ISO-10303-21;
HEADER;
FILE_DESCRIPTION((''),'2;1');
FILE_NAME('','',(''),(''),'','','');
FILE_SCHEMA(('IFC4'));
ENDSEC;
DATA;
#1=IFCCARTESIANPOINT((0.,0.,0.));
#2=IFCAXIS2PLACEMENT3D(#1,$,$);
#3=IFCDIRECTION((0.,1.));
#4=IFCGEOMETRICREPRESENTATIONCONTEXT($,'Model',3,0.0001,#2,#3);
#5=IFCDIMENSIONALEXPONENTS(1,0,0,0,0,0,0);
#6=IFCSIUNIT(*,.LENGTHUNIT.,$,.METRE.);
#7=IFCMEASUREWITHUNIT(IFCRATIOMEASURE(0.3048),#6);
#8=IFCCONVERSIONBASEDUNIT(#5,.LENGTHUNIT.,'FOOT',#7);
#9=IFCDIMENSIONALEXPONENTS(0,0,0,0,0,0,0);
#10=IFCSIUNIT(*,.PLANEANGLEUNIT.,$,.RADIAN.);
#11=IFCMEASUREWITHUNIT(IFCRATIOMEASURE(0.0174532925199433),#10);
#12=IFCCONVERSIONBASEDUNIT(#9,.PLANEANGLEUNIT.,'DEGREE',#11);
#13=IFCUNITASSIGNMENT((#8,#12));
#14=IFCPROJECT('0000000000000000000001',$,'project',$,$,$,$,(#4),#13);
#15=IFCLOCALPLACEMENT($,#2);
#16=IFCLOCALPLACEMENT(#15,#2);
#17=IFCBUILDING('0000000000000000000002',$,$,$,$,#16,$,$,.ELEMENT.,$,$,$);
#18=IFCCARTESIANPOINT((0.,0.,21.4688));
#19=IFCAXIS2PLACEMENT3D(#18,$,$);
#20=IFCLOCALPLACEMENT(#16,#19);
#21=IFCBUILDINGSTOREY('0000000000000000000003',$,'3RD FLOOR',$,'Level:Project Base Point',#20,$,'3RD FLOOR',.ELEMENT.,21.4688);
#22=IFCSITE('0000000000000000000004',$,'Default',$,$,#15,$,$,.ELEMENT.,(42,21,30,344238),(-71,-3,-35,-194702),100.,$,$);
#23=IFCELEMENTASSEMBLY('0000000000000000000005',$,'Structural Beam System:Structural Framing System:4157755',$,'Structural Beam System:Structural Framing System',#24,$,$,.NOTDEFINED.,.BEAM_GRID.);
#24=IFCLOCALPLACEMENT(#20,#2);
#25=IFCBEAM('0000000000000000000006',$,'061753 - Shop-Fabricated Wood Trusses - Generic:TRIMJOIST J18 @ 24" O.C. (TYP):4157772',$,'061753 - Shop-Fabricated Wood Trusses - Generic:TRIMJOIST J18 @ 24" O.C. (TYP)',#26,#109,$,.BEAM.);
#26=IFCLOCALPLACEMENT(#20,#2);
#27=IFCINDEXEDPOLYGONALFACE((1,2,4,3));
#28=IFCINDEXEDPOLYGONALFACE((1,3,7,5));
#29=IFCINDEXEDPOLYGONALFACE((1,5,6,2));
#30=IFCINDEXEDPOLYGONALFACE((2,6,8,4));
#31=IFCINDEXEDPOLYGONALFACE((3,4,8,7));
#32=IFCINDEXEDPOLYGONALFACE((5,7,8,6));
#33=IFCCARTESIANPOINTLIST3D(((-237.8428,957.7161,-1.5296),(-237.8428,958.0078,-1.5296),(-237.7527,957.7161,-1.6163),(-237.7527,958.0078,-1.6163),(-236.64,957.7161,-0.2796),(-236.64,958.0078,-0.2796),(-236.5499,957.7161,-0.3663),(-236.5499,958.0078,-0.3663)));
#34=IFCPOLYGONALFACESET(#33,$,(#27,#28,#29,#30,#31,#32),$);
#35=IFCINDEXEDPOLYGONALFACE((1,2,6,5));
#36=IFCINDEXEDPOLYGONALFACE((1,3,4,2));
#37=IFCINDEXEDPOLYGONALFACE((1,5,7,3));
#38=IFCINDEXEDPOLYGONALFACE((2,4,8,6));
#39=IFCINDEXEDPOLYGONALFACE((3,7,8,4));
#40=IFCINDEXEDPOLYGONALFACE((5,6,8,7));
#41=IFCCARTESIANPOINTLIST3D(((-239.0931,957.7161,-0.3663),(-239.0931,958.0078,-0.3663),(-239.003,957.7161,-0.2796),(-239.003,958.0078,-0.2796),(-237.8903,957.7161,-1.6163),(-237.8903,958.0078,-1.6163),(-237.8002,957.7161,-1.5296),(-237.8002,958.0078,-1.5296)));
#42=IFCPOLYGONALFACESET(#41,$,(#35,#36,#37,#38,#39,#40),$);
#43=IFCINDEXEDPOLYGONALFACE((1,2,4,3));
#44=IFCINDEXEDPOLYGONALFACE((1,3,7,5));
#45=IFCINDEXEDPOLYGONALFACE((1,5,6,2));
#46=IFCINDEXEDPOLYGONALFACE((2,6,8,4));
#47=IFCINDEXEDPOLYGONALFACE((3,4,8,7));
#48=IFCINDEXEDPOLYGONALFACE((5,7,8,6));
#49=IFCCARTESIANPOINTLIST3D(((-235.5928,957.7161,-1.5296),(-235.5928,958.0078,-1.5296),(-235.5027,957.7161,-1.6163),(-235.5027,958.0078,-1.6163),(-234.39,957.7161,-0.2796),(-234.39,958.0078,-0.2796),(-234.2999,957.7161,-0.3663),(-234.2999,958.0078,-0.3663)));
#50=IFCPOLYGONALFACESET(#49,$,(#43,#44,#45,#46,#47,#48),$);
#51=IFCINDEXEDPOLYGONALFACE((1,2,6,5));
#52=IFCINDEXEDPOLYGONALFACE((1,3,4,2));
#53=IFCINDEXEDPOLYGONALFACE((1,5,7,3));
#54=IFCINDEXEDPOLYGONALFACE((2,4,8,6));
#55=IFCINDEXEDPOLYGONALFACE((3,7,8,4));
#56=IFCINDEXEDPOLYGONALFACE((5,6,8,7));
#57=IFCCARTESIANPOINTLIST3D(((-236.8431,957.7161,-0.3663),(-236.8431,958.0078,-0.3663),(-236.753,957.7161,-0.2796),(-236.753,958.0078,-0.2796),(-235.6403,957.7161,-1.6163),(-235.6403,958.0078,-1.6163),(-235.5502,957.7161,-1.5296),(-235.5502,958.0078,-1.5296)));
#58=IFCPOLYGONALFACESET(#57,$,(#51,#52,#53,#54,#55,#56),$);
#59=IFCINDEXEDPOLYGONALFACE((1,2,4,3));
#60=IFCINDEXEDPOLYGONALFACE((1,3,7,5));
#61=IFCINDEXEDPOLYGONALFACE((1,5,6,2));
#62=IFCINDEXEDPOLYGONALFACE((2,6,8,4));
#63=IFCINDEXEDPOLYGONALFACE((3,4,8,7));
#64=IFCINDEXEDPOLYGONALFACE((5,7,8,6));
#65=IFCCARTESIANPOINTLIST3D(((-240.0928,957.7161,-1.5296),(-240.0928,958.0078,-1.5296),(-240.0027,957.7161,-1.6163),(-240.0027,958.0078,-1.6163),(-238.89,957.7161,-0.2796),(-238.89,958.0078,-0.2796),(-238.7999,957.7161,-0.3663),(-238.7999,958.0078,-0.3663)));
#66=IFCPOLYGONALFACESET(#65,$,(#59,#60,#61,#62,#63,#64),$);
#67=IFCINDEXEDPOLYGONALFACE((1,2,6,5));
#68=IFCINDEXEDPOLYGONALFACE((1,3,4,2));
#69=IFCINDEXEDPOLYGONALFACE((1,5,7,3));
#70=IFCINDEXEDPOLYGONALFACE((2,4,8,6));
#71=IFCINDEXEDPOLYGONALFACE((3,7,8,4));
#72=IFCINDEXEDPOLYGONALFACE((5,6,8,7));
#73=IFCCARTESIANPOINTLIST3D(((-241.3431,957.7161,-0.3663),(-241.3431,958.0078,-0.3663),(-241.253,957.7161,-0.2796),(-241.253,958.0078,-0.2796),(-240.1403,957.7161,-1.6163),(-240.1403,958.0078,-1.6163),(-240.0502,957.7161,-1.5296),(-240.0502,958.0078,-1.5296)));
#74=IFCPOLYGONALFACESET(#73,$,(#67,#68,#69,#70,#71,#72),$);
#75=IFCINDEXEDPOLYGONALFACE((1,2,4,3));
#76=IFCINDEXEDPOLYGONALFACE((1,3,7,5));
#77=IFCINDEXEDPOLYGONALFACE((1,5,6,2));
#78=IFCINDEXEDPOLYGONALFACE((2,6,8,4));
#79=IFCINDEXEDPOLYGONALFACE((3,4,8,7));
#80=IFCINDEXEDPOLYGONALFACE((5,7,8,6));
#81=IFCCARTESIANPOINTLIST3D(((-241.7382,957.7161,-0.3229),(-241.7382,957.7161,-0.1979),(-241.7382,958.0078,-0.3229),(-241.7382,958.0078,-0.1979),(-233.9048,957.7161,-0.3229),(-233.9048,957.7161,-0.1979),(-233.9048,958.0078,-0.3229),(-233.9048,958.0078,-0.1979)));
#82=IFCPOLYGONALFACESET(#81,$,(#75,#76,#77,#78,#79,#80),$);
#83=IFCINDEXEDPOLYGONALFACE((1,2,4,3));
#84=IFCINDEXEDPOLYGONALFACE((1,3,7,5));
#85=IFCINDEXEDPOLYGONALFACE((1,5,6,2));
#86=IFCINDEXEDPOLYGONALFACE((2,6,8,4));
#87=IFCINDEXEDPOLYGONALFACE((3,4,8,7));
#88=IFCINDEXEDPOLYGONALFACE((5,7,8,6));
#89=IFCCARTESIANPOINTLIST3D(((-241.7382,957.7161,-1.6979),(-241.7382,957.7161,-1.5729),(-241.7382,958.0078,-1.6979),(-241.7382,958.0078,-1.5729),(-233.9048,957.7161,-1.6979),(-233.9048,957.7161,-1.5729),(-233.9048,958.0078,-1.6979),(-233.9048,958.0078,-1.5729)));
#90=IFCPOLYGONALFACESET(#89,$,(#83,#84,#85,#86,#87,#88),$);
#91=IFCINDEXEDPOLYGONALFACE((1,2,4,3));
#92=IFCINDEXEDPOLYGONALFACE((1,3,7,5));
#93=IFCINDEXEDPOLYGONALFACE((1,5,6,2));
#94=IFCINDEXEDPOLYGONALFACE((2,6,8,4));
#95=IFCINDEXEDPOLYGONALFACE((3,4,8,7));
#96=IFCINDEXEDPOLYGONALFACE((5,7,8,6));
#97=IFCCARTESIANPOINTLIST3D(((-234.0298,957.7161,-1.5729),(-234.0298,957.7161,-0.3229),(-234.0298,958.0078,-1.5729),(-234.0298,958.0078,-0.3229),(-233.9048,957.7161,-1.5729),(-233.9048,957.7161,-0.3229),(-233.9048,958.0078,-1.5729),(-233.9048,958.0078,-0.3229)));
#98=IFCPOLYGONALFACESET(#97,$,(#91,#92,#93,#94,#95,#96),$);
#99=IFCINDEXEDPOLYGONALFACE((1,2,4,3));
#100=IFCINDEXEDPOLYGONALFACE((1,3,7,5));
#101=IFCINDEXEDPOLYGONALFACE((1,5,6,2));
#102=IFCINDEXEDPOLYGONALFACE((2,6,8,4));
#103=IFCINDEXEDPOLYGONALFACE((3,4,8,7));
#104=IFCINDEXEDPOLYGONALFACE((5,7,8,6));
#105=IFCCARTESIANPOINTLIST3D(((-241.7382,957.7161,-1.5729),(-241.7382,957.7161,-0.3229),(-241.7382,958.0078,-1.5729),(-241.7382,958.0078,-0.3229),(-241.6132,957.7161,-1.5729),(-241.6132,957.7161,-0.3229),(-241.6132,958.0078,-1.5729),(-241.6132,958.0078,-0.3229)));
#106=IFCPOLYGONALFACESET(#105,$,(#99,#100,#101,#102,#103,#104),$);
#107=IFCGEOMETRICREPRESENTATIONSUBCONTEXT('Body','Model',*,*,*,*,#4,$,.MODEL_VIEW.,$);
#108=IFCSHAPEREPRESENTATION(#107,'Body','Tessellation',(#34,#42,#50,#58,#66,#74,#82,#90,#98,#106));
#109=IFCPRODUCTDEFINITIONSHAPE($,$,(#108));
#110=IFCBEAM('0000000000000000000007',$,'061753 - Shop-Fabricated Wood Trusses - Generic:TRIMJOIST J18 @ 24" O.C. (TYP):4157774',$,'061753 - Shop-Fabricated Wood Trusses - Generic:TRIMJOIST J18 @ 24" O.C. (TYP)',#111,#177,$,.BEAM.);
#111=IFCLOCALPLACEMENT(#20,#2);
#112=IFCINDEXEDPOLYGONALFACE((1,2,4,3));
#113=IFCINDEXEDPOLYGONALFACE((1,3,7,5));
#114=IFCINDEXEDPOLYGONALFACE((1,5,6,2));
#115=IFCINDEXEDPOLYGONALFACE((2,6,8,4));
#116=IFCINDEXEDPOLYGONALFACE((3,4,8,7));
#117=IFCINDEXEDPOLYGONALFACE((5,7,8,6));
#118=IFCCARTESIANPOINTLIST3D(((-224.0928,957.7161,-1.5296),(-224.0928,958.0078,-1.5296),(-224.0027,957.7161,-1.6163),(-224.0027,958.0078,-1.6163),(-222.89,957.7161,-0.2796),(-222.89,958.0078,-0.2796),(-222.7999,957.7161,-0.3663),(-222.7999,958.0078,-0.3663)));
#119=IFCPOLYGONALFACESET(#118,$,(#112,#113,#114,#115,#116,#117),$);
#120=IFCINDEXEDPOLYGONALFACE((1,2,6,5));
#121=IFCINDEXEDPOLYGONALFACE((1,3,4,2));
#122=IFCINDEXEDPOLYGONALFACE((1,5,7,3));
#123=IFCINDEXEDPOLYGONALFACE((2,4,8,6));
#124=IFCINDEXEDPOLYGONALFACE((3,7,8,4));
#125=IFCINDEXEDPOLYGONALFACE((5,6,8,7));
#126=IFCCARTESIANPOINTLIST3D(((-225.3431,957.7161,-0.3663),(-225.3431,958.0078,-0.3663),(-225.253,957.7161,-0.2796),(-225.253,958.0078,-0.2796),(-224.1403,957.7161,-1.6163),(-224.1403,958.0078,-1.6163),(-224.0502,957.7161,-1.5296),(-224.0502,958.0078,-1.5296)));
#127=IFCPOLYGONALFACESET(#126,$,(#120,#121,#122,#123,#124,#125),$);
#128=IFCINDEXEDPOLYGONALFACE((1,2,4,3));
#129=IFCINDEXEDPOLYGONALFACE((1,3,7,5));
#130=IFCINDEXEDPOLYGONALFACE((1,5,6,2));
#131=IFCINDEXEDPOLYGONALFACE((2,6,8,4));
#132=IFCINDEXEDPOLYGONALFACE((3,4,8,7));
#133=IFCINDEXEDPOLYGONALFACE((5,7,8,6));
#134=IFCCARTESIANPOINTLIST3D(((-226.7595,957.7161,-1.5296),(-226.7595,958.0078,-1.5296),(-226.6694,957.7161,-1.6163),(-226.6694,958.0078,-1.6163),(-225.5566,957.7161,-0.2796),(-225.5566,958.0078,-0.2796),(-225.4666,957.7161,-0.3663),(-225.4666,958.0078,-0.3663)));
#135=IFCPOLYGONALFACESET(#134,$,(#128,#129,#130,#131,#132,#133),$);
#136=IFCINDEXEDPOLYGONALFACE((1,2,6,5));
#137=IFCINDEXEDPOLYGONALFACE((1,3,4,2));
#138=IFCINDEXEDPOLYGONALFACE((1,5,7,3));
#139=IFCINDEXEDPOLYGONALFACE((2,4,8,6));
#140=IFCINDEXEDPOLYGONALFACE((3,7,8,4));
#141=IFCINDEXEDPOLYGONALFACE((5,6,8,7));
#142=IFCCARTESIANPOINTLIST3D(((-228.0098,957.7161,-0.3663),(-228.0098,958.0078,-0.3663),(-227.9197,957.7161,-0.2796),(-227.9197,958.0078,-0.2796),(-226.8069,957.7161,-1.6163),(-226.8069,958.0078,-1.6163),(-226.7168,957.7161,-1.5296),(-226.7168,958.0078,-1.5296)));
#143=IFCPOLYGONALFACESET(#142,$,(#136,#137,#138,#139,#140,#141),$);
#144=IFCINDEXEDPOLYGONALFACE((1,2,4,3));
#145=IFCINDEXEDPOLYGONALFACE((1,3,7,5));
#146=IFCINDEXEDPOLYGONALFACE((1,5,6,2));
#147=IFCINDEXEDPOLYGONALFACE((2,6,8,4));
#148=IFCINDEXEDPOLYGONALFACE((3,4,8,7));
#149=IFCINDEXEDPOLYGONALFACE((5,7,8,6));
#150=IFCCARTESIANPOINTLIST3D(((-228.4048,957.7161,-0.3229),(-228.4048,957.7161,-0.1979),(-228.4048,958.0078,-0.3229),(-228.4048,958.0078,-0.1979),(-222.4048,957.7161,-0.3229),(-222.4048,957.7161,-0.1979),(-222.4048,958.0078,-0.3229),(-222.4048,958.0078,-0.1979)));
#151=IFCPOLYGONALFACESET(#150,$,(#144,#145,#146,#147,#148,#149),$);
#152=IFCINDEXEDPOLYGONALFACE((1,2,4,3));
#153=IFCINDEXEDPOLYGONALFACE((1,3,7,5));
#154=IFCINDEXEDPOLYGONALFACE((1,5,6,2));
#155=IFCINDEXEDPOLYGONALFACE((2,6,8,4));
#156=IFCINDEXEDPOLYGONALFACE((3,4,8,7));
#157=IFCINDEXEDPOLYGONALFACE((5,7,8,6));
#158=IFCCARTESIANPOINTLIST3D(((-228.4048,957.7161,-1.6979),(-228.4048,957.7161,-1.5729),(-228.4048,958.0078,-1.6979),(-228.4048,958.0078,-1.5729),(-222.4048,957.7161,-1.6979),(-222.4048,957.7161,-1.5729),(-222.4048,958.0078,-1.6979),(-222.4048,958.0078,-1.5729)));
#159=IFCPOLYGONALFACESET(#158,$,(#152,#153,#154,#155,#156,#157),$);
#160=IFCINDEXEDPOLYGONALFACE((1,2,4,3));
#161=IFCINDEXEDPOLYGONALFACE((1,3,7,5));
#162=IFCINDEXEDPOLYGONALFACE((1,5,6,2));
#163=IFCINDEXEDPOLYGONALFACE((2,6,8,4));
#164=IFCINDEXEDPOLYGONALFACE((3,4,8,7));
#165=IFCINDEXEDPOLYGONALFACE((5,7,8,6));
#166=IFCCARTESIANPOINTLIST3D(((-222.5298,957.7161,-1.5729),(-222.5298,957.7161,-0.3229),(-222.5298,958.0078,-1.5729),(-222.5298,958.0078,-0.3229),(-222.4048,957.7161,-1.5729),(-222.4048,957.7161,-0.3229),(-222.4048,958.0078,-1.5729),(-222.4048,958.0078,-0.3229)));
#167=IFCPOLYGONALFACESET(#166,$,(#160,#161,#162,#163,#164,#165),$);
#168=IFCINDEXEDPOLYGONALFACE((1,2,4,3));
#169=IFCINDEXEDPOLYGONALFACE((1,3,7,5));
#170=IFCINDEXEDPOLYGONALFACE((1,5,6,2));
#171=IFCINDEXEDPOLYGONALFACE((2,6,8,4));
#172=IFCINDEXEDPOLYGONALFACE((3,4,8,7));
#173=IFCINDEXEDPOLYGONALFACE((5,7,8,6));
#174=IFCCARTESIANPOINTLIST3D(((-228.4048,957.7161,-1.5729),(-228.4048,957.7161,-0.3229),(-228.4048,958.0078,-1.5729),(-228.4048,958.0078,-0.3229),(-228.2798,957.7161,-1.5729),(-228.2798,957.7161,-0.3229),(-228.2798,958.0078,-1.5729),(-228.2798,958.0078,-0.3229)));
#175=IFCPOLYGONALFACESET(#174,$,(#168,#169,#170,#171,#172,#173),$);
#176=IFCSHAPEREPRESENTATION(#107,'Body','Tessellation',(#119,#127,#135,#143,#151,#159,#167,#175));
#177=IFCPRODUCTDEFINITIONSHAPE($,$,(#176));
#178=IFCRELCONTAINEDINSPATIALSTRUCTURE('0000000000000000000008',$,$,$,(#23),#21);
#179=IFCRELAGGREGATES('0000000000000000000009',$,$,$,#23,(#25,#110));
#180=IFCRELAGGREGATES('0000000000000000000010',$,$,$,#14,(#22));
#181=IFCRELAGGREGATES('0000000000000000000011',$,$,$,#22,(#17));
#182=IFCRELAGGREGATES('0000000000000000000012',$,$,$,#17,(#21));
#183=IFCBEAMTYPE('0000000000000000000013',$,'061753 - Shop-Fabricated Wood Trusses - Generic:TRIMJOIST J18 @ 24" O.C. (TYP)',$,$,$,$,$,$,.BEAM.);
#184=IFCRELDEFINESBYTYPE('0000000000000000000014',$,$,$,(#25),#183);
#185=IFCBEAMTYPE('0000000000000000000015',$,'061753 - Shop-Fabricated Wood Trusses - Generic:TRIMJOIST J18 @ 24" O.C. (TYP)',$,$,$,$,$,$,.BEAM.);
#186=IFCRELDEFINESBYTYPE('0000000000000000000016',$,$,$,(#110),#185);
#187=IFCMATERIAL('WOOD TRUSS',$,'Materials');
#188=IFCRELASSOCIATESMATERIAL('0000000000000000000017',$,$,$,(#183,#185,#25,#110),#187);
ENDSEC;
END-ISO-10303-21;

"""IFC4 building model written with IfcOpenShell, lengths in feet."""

from ifc_helpers import new_model, entity, si_unit, converted_unit, direction, frame, frame_2d, origin, origin_2d_with_axis, place, context, subcontext, project, spatial, rectangle, extrude, source, transform, mapped, material, material_profile, profile_set, profile_usage, type_object, type_shapes, element, aggregate, save


model = new_model("IFC4")

# Units and contexts
model_context = context("Model", 3, precision=0.0001, world=origin(), true_north=direction((0.0, 1.0)))
body_context = subcontext(model_context, "Body", "Model", "MODEL_VIEW")
ifc_project = project(units=[converted_unit("LENGTHUNIT", "FOOT", entity("IfcRatioMeasure", 0.3048), si_unit("LENGTHUNIT", "METRE"), dimensions=[1, 0, 0, 0, 0, 0, 0]), converted_unit("PLANEANGLEUNIT", "DEGREE", entity("IfcRatioMeasure", 0.0174532925199433), si_unit("PLANEANGLEUNIT", "RADIAN"), dimensions=[0, 0, 0, 0, 0, 0, 0])], contexts=[model_context])

# Site, building, storey
site_placement = place(None, origin())
site = spatial("IfcSite", under=ifc_project, at=site_placement, Name="Default", CompositionType="ELEMENT", RefLatitude=(42, 21, 30, 344238), RefLongitude=(-71, -3, -35, -194702), RefElevation=100.0)
building_placement = place(site_placement, origin())
building = spatial("IfcBuilding", under=site, at=building_placement, CompositionType="ELEMENT")
storey_placement = place(building_placement, frame((0.0, 0.0, 21.4688)))
storey = spatial("IfcBuildingStorey", under=building, at=storey_placement, Name="3RD FLOOR", ObjectType="Level:Project Base Point", LongName="3RD FLOOR", CompositionType="ELEMENT", Elevation=21.4688)

# Element assembly, beams
assembly_1_placement = place(storey_placement, origin())
assembly_1 = element("IfcElementAssembly", 1, at=assembly_1_placement, inside=storey, Name="Structural Beam System:Structural Framing System:4157755", ObjectType="Structural Beam System:Structural Framing System", AssemblyPlace="NOTDEFINED", PredefinedType="BEAM_GRID")
ifc_material_1 = material(Name="WOOD TRUSS", Category="Materials")
ifc_material_profile_1 = material_profile(ifc_material_1, rectangle(XDim=1.7347, YDim=0.125, at=frame_2d((0.0, 0.0), x_axis=(1.0, 0.0))), Name="TRIMJOIST J18 @ 24\" O.C. (TYP)")
ifc_material_profile_2 = material_profile(ifc_material_1, rectangle(XDim=1.7347, YDim=0.125, at=frame_2d((0.0, 0.0), x_axis=(1.0, 0.0))), Name="TRIMJOIST J18 @ 24\" O.C. (TYP)")
ifc_material_profile_3 = material_profile(ifc_material_1, rectangle(XDim=1.7347, YDim=0.125, at=frame_2d((0.0, 0.0), x_axis=(1.0, 0.0))), Name="TRIMJOIST J18 @ 24\" O.C. (TYP)")
ifc_material_profile_4 = material_profile(ifc_material_1, rectangle(XDim=1.7347, YDim=0.125, at=frame_2d((0.0, 0.0), x_axis=(1.0, 0.0))), Name="TRIMJOIST J18 @ 24\" O.C. (TYP)")
ifc_material_profile_5 = material_profile(ifc_material_1, rectangle(XDim=1.7347, YDim=0.125, at=frame_2d((0.0, 0.0), x_axis=(1.0, 0.0))), Name="TRIMJOIST J18 @ 24\" O.C. (TYP)")
ifc_material_profile_6 = material_profile(ifc_material_1, rectangle(XDim=1.7347, YDim=0.125, at=frame_2d((0.0, 0.0), x_axis=(1.0, 0.0))), Name="TRIMJOIST J18 @ 24\" O.C. (TYP)")
ifc_material_profile_7 = material_profile(ifc_material_1, rectangle(XDim=1.7347, YDim=0.125, at=frame_2d((0.0, 0.0), x_axis=(1.0, 0.0))), Name="TRIMJOIST J18 @ 24\" O.C. (TYP)")
ifc_material_profile_8 = material_profile(ifc_material_1, rectangle(XDim=1.7347, YDim=0.125, at=frame_2d((0.0, 0.0), x_axis=(1.0, 0.0))), Name="TRIMJOIST J18 @ 24\" O.C. (TYP)")
ifc_material_profile_9 = material_profile(ifc_material_1, rectangle(XDim=1.7347, YDim=0.125, at=frame_2d((0.0, 0.0), x_axis=(1.0, 0.0))), Name="TRIMJOIST J18 @ 24\" O.C. (TYP)")
ifc_material_profile_10 = material_profile(ifc_material_1, rectangle(XDim=1.7347, YDim=0.125, at=origin_2d_with_axis()), Name="TRIMJOIST J18 @ 24\" O.C. (TYP)")
ifc_material_profile_11 = material_profile(ifc_material_1, rectangle(XDim=0.125, YDim=0.2917, at=origin_2d_with_axis()), Name="TRIMJOIST J18 @ 24\" O.C. (TYP)")
ifc_material_profile_12 = material_profile(ifc_material_1, rectangle(XDim=0.125, YDim=0.2917, at=origin_2d_with_axis()), Name="TRIMJOIST J18 @ 24\" O.C. (TYP)")
ifc_material_profile_13 = material_profile(ifc_material_1, rectangle(XDim=1.25, YDim=0.2917, at=origin_2d_with_axis()), Name="TRIMJOIST J18 @ 24\" O.C. (TYP)")
ifc_material_profile_14 = material_profile(ifc_material_1, rectangle(XDim=1.25, YDim=0.2917, at=origin_2d_with_axis()), Name="TRIMJOIST J18 @ 24\" O.C. (TYP)")
ifc_profile_set_1 = profile_set([ifc_material_profile_1, ifc_material_profile_2, ifc_material_profile_3, ifc_material_profile_4, ifc_material_profile_5, ifc_material_profile_6, ifc_material_profile_7, ifc_material_profile_8, ifc_material_profile_9, ifc_material_profile_10, ifc_material_profile_11, ifc_material_profile_12, ifc_material_profile_13, ifc_material_profile_14], Name="TRIMJOIST J18 @ 24\" O.C. (TYP)")
ifc_profile_usage_1 = profile_usage(ifc_profile_set_1, cardinal=8)
beam_type_1 = type_object("IfcBeamType", Name="061753 - Shop-Fabricated Wood Trusses - Generic:TRIMJOIST J18 @ 24\" O.C. (TYP)", PredefinedType="BEAM", material=ifc_profile_set_1)
shared_shape_1 = source(origin(), body_context, "Body", "SweptSolid", [
    extrude(rectangle(XDim=1.7347, YDim=0.125, at=frame_2d((0.0, 0.0), x_axis=(1.0, 0.0))), frame((0.6251, -0.1458, 0.0), z_axis=(0.0, 1.0, 0.0), x_axis=(0.693383, 0.0, 0.720569)), (0.0, 0.0, 1.0), 0.2917),
    extrude(rectangle(XDim=1.7347, YDim=0.125, at=frame_2d((0.0, 0.0), x_axis=(1.0, 0.0))), frame((-0.6251, -0.1458, 0.0), z_axis=(0.0, 1.0, 0.0), x_axis=(0.693383, 0.0, -0.720569)), (0.0, 0.0, 1.0), 0.2917),
    extrude(rectangle(XDim=1.7347, YDim=0.125, at=frame_2d((0.0, 0.0), x_axis=(1.0, 0.0))), frame((2.8751, -0.1458, 0.0), z_axis=(0.0, 1.0, 0.0), x_axis=(0.693383, 0.0, 0.720569)), (0.0, 0.0, 1.0), 0.2917),
    extrude(rectangle(XDim=1.7347, YDim=0.125, at=frame_2d((0.0, 0.0), x_axis=(1.0, 0.0))), frame((1.6249, -0.1458, 0.0), z_axis=(0.0, 1.0, 0.0), x_axis=(0.693383, 0.0, -0.720569)), (0.0, 0.0, 1.0), 0.2917),
    extrude(rectangle(XDim=1.7347, YDim=0.125, at=frame_2d((0.0, 0.0), x_axis=(1.0, 0.0))), frame((-1.6249, -0.1458, 0.0), z_axis=(0.0, 1.0, 0.0), x_axis=(0.693383, 0.0, 0.720569)), (0.0, 0.0, 1.0), 0.2917),
    extrude(rectangle(XDim=1.7347, YDim=0.125, at=origin_2d_with_axis()), frame((-2.8751, -0.1458, 0.0), z_axis=(0.0, 1.0, 0.0), x_axis=(0.693383, 0.0, -0.720569)), (0.0, 0.0, 1.0), 0.2917),
    extrude(rectangle(XDim=0.125, YDim=0.2917, at=origin_2d_with_axis()), frame((-3.9167, 0.0, 0.6875), z_axis=(1.0, 0.0, 0.0), x_axis=(0.0, 0.0, -1.0)), (0.0, 0.0, 1.0), 7.8333),
    extrude(rectangle(XDim=0.125, YDim=0.2917, at=origin_2d_with_axis()), frame((-3.9167, 0.0, -0.6875), z_axis=(1.0, 0.0, 0.0), x_axis=(0.0, 0.0, -1.0)), (0.0, 0.0, 1.0), 7.8333),
    extrude(rectangle(XDim=1.25, YDim=0.2917, at=origin_2d_with_axis()), frame((3.7917, 0.0, 0.0), z_axis=(1.0, 0.0, 0.0), x_axis=(0.0, 0.0, -1.0)), (0.0, 0.0, 1.0), 0.125),
    extrude(rectangle(XDim=1.25, YDim=0.2917, at=origin_2d_with_axis()), frame((-3.9167, 0.0, 0.0), z_axis=(1.0, 0.0, 0.0), x_axis=(0.0, 0.0, -1.0)), (0.0, 0.0, 1.0), 0.125),
])
type_shapes(beam_type_1, [shared_shape_1])
beam_1_placement = place(assembly_1_placement, frame((-237.8215, 957.8619, -0.9479)))
beam_1 = element("IfcBeam", 2, at=beam_1_placement, type_object=beam_type_1, material=ifc_profile_usage_1, Name="061753 - Shop-Fabricated Wood Trusses - Generic:TRIMJOIST J18 @ 24\" O.C. (TYP):4157772", ObjectType="061753 - Shop-Fabricated Wood Trusses - Generic:TRIMJOIST J18 @ 24\" O.C. (TYP)", PredefinedType="BEAM", context=body_context, shape_type="MappedRepresentation", body=[
    mapped(shared_shape_1, transform((0.0, 0.0, 0.0), scale=1.0)),
])
ifc_profile_usage_2 = profile_usage(ifc_profile_set_1, cardinal=8)
beam_type_2 = type_object("IfcBeamType", Name="061753 - Shop-Fabricated Wood Trusses - Generic:TRIMJOIST J18 @ 24\" O.C. (TYP)", PredefinedType="BEAM", material=ifc_profile_set_1)
shared_shape_2 = source(origin(), body_context, "Body", "SweptSolid", [
    extrude(rectangle(XDim=1.7347, YDim=0.125, at=frame_2d((0.0, 0.0), x_axis=(1.0, 0.0))), frame((1.9585, -0.1458, 0.0), z_axis=(0.0, 1.0, 0.0), x_axis=(0.693383, 0.0, 0.720569)), (0.0, 0.0, 1.0), 0.2917),
    extrude(rectangle(XDim=1.7347, YDim=0.125, at=frame_2d((0.0, 0.0), x_axis=(1.0, 0.0))), frame((0.7082, -0.1458, 0.0), z_axis=(0.0, 1.0, 0.0), x_axis=(0.693383, 0.0, -0.720569)), (0.0, 0.0, 1.0), 0.2917),
    extrude(rectangle(XDim=1.7347, YDim=0.125, at=frame_2d((0.0, 0.0), x_axis=(1.0, 0.0))), frame((-0.7082, -0.1458, 0.0), z_axis=(0.0, 1.0, 0.0), x_axis=(0.693383, 0.0, 0.720569)), (0.0, 0.0, 1.0), 0.2917),
    extrude(rectangle(XDim=1.7347, YDim=0.125, at=frame_2d((0.0, 0.0), x_axis=(1.0, 0.0))), frame((-1.9585, -0.1458, 0.0), z_axis=(0.0, 1.0, 0.0), x_axis=(0.693383, 0.0, -0.720569)), (0.0, 0.0, 1.0), 0.2917),
    extrude(rectangle(XDim=0.125, YDim=0.2917, at=origin_2d_with_axis()), frame((-3.0, 0.0, 0.6875), z_axis=(1.0, 0.0, 0.0), x_axis=(0.0, 0.0, -1.0)), (0.0, 0.0, 1.0), 6.0),
    extrude(rectangle(XDim=0.125, YDim=0.2917, at=origin_2d_with_axis()), frame((-3.0, 0.0, -0.6875), z_axis=(1.0, 0.0, 0.0), x_axis=(0.0, 0.0, -1.0)), (0.0, 0.0, 1.0), 6.0),
    extrude(rectangle(XDim=1.25, YDim=0.2917, at=origin_2d_with_axis()), frame((2.875, 0.0, 0.0), z_axis=(1.0, 0.0, 0.0), x_axis=(0.0, 0.0, -1.0)), (0.0, 0.0, 1.0), 0.125),
    extrude(rectangle(XDim=1.25, YDim=0.2917, at=origin_2d_with_axis()), frame((-3.0, 0.0, 0.0), z_axis=(1.0, 0.0, 0.0), x_axis=(0.0, 0.0, -1.0)), (0.0, 0.0, 1.0), 0.125),
])
type_shapes(beam_type_2, [shared_shape_2])
beam_2_placement = place(assembly_1_placement, frame((-225.4048, 957.8619, -0.9479)))
beam_2 = element("IfcBeam", 3, at=beam_2_placement, type_object=beam_type_2, material=ifc_profile_usage_2, Name="061753 - Shop-Fabricated Wood Trusses - Generic:TRIMJOIST J18 @ 24\" O.C. (TYP):4157774", ObjectType="061753 - Shop-Fabricated Wood Trusses - Generic:TRIMJOIST J18 @ 24\" O.C. (TYP)", PredefinedType="BEAM", context=body_context, shape_type="MappedRepresentation", body=[
    mapped(shared_shape_2, transform((0.0, 0.0, 0.0), scale=1.0)),
])
aggregate(assembly_1, [beam_1, beam_2])

save(model, "model.ifc")
